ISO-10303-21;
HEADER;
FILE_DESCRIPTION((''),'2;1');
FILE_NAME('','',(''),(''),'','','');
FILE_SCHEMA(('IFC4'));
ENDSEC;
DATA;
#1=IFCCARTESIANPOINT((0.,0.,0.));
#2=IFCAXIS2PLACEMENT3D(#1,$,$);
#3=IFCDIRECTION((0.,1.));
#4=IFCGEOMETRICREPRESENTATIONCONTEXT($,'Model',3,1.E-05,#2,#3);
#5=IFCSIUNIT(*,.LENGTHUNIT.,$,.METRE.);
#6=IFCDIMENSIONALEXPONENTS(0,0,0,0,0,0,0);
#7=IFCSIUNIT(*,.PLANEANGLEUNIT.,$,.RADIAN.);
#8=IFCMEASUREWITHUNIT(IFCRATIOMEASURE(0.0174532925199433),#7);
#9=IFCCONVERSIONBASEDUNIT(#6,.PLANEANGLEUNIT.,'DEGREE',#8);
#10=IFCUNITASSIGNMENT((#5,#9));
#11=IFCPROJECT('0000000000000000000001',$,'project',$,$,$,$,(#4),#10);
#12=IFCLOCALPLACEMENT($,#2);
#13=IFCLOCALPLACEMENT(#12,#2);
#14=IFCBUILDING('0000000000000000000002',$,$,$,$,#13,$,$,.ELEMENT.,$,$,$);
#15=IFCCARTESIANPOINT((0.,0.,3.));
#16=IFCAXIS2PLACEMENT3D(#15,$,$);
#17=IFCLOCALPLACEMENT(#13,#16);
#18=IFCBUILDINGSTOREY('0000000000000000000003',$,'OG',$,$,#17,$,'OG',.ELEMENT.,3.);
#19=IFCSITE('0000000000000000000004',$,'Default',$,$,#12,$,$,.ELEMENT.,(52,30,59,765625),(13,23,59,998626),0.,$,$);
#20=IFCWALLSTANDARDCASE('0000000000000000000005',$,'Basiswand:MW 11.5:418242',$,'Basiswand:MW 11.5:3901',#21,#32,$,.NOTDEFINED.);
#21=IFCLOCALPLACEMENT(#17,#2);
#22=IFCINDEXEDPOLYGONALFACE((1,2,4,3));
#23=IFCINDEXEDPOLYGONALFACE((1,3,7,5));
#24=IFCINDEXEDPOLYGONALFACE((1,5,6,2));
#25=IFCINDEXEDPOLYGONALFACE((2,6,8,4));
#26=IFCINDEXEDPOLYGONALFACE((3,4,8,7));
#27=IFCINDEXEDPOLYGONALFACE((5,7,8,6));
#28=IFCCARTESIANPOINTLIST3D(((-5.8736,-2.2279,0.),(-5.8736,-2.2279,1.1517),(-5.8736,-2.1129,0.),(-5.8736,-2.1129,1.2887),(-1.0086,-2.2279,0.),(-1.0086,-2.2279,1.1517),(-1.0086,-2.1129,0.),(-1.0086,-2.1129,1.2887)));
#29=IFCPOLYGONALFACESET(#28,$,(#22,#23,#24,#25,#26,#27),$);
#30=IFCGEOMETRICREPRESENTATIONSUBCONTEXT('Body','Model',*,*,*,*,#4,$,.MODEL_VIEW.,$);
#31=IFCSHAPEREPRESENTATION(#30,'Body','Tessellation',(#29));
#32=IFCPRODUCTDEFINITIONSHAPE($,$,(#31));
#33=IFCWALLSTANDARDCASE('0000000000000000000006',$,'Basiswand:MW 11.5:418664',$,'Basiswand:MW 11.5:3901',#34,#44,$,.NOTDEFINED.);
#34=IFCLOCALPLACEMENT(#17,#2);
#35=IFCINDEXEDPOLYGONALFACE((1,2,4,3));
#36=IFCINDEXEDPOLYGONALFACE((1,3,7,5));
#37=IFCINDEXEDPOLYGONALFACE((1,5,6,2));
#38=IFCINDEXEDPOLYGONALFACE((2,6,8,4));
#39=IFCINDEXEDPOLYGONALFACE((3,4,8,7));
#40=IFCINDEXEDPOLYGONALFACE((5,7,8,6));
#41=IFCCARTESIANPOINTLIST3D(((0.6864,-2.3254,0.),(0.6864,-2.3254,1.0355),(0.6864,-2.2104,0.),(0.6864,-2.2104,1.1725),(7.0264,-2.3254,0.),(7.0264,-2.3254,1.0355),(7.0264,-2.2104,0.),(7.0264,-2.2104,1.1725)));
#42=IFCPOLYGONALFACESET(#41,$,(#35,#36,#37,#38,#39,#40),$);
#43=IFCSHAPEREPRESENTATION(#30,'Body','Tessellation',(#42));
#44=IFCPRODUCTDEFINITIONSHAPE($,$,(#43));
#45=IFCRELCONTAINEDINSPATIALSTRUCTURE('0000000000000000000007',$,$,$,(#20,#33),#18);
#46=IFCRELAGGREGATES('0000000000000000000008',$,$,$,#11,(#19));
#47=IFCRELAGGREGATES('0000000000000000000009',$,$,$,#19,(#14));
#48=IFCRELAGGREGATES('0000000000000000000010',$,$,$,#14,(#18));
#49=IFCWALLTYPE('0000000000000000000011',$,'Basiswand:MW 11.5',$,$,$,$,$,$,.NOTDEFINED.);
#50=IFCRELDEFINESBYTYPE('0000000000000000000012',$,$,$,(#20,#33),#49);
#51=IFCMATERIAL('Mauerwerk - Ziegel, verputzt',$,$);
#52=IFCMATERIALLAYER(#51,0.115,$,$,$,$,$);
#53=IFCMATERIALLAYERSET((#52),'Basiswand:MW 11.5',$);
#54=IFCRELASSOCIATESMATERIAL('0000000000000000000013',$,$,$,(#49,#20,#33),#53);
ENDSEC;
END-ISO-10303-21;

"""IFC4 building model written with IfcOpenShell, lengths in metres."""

from ifc_helpers import new_model, entity, si_unit, converted_unit, direction, frame, frame_2d, origin, place, context, subcontext, project, spatial, polyline, rectangle, extrude, clip, bounded_halfspace, material, layer, layer_set, layer_usage, type_object, element, save


model = new_model("IFC4")

# Units and contexts
model_context = context("Model", 3, precision=1e-05, world=origin(), true_north=direction((0.0, 1.0)))
body_context = subcontext(model_context, "Body", "Model", "MODEL_VIEW")
ifc_project = project(units=[si_unit("LENGTHUNIT", "METRE"), converted_unit("PLANEANGLEUNIT", "DEGREE", entity("IfcRatioMeasure", 0.0174532925199433), si_unit("PLANEANGLEUNIT", "RADIAN"), dimensions=[0, 0, 0, 0, 0, 0, 0])], contexts=[model_context])

# Site, building, storey
site_placement = place(None, origin())
site = spatial("IfcSite", under=ifc_project, at=site_placement, Name="Default", CompositionType="ELEMENT", RefLatitude=(52, 30, 59, 765625), RefLongitude=(13, 23, 59, 998626), RefElevation=0.0)
building_placement = place(site_placement, origin())
building = spatial("IfcBuilding", under=site, at=building_placement, CompositionType="ELEMENT")
storey_placement = place(building_placement, frame((0.0, 0.0, 3.0)))
storey = spatial("IfcBuildingStorey", under=building, at=storey_placement, Name="OG", LongName="OG", CompositionType="ELEMENT", Elevation=3.0)

# Shared definitions
ifc_material_1 = material(Name="Mauerwerk - Ziegel, verputzt")

# Shared definitions
ifc_layer_1 = layer(ifc_material_1, 0.115)
ifc_layer_set_1 = layer_set([ifc_layer_1], Name="Basiswand:MW 11.5")
wall_type_1 = type_object("IfcWallType", Name="Basiswand:MW 11.5", PredefinedType="NOTDEFINED", material=ifc_layer_set_1)

# Walls
ifc_layer_usage_1 = layer_usage(ifc_layer_set_1, "AXIS2", "NEGATIVE", 0.0575)
wall_1_placement = place(storey_placement, frame((-5.8736, -2.1704, 0.0)))
element("IfcWallStandardCase", 1, at=wall_1_placement, inside=storey, type_object=wall_type_1, material=ifc_layer_usage_1, Name="Basiswand:MW 11.5:418242", ObjectType="Basiswand:MW 11.5:3901", PredefinedType="NOTDEFINED", context=body_context, shape_type="Clipping", body=[
    clip(extrude(rectangle(XDim=4.865, YDim=0.115, at=frame_2d((2.4325, 0.0), x_axis=(-1.0, 0.0))), origin(), (0.0, 0.0, 1.0), 1.2887), bounded_halfspace(frame((0.0, -0.0575, 1.1517), z_axis=(0.0, 0.766044, -0.642788), x_axis=(-1.0, 0.0, 0.0)), True, frame((0.0, -0.0575, 1.1517)), polyline([(0.0, 0.0), (4.865, 0.0), (4.865, 0.115), (0.0, 0.115), (0.0, 0.0)]))),
])
ifc_layer_usage_2 = layer_usage(ifc_layer_set_1, "AXIS2", "NEGATIVE", 0.0575)
wall_2_placement = place(storey_placement, frame((0.6864, -2.2679, 0.0)))
element("IfcWallStandardCase", 2, at=wall_2_placement, inside=storey, type_object=wall_type_1, material=ifc_layer_usage_2, Name="Basiswand:MW 11.5:418664", ObjectType="Basiswand:MW 11.5:3901", PredefinedType="NOTDEFINED", context=body_context, shape_type="Clipping", body=[
    clip(extrude(rectangle(XDim=6.34, YDim=0.115, at=frame_2d((3.17, 0.0), x_axis=(-1.0, 0.0))), origin(), (0.0, 0.0, 1.0), 1.1725), bounded_halfspace(frame((0.0, -0.0575, 1.0355), z_axis=(0.0, 0.766044, -0.642788), x_axis=(-1.0, 0.0, 0.0)), True, frame((0.0, -0.0575, 1.0355)), polyline([(0.0, 0.0), (6.34, 0.0), (6.34, 0.115), (0.0, 0.115), (0.0, 0.0)]))),
])

save(model, "model.ifc")
